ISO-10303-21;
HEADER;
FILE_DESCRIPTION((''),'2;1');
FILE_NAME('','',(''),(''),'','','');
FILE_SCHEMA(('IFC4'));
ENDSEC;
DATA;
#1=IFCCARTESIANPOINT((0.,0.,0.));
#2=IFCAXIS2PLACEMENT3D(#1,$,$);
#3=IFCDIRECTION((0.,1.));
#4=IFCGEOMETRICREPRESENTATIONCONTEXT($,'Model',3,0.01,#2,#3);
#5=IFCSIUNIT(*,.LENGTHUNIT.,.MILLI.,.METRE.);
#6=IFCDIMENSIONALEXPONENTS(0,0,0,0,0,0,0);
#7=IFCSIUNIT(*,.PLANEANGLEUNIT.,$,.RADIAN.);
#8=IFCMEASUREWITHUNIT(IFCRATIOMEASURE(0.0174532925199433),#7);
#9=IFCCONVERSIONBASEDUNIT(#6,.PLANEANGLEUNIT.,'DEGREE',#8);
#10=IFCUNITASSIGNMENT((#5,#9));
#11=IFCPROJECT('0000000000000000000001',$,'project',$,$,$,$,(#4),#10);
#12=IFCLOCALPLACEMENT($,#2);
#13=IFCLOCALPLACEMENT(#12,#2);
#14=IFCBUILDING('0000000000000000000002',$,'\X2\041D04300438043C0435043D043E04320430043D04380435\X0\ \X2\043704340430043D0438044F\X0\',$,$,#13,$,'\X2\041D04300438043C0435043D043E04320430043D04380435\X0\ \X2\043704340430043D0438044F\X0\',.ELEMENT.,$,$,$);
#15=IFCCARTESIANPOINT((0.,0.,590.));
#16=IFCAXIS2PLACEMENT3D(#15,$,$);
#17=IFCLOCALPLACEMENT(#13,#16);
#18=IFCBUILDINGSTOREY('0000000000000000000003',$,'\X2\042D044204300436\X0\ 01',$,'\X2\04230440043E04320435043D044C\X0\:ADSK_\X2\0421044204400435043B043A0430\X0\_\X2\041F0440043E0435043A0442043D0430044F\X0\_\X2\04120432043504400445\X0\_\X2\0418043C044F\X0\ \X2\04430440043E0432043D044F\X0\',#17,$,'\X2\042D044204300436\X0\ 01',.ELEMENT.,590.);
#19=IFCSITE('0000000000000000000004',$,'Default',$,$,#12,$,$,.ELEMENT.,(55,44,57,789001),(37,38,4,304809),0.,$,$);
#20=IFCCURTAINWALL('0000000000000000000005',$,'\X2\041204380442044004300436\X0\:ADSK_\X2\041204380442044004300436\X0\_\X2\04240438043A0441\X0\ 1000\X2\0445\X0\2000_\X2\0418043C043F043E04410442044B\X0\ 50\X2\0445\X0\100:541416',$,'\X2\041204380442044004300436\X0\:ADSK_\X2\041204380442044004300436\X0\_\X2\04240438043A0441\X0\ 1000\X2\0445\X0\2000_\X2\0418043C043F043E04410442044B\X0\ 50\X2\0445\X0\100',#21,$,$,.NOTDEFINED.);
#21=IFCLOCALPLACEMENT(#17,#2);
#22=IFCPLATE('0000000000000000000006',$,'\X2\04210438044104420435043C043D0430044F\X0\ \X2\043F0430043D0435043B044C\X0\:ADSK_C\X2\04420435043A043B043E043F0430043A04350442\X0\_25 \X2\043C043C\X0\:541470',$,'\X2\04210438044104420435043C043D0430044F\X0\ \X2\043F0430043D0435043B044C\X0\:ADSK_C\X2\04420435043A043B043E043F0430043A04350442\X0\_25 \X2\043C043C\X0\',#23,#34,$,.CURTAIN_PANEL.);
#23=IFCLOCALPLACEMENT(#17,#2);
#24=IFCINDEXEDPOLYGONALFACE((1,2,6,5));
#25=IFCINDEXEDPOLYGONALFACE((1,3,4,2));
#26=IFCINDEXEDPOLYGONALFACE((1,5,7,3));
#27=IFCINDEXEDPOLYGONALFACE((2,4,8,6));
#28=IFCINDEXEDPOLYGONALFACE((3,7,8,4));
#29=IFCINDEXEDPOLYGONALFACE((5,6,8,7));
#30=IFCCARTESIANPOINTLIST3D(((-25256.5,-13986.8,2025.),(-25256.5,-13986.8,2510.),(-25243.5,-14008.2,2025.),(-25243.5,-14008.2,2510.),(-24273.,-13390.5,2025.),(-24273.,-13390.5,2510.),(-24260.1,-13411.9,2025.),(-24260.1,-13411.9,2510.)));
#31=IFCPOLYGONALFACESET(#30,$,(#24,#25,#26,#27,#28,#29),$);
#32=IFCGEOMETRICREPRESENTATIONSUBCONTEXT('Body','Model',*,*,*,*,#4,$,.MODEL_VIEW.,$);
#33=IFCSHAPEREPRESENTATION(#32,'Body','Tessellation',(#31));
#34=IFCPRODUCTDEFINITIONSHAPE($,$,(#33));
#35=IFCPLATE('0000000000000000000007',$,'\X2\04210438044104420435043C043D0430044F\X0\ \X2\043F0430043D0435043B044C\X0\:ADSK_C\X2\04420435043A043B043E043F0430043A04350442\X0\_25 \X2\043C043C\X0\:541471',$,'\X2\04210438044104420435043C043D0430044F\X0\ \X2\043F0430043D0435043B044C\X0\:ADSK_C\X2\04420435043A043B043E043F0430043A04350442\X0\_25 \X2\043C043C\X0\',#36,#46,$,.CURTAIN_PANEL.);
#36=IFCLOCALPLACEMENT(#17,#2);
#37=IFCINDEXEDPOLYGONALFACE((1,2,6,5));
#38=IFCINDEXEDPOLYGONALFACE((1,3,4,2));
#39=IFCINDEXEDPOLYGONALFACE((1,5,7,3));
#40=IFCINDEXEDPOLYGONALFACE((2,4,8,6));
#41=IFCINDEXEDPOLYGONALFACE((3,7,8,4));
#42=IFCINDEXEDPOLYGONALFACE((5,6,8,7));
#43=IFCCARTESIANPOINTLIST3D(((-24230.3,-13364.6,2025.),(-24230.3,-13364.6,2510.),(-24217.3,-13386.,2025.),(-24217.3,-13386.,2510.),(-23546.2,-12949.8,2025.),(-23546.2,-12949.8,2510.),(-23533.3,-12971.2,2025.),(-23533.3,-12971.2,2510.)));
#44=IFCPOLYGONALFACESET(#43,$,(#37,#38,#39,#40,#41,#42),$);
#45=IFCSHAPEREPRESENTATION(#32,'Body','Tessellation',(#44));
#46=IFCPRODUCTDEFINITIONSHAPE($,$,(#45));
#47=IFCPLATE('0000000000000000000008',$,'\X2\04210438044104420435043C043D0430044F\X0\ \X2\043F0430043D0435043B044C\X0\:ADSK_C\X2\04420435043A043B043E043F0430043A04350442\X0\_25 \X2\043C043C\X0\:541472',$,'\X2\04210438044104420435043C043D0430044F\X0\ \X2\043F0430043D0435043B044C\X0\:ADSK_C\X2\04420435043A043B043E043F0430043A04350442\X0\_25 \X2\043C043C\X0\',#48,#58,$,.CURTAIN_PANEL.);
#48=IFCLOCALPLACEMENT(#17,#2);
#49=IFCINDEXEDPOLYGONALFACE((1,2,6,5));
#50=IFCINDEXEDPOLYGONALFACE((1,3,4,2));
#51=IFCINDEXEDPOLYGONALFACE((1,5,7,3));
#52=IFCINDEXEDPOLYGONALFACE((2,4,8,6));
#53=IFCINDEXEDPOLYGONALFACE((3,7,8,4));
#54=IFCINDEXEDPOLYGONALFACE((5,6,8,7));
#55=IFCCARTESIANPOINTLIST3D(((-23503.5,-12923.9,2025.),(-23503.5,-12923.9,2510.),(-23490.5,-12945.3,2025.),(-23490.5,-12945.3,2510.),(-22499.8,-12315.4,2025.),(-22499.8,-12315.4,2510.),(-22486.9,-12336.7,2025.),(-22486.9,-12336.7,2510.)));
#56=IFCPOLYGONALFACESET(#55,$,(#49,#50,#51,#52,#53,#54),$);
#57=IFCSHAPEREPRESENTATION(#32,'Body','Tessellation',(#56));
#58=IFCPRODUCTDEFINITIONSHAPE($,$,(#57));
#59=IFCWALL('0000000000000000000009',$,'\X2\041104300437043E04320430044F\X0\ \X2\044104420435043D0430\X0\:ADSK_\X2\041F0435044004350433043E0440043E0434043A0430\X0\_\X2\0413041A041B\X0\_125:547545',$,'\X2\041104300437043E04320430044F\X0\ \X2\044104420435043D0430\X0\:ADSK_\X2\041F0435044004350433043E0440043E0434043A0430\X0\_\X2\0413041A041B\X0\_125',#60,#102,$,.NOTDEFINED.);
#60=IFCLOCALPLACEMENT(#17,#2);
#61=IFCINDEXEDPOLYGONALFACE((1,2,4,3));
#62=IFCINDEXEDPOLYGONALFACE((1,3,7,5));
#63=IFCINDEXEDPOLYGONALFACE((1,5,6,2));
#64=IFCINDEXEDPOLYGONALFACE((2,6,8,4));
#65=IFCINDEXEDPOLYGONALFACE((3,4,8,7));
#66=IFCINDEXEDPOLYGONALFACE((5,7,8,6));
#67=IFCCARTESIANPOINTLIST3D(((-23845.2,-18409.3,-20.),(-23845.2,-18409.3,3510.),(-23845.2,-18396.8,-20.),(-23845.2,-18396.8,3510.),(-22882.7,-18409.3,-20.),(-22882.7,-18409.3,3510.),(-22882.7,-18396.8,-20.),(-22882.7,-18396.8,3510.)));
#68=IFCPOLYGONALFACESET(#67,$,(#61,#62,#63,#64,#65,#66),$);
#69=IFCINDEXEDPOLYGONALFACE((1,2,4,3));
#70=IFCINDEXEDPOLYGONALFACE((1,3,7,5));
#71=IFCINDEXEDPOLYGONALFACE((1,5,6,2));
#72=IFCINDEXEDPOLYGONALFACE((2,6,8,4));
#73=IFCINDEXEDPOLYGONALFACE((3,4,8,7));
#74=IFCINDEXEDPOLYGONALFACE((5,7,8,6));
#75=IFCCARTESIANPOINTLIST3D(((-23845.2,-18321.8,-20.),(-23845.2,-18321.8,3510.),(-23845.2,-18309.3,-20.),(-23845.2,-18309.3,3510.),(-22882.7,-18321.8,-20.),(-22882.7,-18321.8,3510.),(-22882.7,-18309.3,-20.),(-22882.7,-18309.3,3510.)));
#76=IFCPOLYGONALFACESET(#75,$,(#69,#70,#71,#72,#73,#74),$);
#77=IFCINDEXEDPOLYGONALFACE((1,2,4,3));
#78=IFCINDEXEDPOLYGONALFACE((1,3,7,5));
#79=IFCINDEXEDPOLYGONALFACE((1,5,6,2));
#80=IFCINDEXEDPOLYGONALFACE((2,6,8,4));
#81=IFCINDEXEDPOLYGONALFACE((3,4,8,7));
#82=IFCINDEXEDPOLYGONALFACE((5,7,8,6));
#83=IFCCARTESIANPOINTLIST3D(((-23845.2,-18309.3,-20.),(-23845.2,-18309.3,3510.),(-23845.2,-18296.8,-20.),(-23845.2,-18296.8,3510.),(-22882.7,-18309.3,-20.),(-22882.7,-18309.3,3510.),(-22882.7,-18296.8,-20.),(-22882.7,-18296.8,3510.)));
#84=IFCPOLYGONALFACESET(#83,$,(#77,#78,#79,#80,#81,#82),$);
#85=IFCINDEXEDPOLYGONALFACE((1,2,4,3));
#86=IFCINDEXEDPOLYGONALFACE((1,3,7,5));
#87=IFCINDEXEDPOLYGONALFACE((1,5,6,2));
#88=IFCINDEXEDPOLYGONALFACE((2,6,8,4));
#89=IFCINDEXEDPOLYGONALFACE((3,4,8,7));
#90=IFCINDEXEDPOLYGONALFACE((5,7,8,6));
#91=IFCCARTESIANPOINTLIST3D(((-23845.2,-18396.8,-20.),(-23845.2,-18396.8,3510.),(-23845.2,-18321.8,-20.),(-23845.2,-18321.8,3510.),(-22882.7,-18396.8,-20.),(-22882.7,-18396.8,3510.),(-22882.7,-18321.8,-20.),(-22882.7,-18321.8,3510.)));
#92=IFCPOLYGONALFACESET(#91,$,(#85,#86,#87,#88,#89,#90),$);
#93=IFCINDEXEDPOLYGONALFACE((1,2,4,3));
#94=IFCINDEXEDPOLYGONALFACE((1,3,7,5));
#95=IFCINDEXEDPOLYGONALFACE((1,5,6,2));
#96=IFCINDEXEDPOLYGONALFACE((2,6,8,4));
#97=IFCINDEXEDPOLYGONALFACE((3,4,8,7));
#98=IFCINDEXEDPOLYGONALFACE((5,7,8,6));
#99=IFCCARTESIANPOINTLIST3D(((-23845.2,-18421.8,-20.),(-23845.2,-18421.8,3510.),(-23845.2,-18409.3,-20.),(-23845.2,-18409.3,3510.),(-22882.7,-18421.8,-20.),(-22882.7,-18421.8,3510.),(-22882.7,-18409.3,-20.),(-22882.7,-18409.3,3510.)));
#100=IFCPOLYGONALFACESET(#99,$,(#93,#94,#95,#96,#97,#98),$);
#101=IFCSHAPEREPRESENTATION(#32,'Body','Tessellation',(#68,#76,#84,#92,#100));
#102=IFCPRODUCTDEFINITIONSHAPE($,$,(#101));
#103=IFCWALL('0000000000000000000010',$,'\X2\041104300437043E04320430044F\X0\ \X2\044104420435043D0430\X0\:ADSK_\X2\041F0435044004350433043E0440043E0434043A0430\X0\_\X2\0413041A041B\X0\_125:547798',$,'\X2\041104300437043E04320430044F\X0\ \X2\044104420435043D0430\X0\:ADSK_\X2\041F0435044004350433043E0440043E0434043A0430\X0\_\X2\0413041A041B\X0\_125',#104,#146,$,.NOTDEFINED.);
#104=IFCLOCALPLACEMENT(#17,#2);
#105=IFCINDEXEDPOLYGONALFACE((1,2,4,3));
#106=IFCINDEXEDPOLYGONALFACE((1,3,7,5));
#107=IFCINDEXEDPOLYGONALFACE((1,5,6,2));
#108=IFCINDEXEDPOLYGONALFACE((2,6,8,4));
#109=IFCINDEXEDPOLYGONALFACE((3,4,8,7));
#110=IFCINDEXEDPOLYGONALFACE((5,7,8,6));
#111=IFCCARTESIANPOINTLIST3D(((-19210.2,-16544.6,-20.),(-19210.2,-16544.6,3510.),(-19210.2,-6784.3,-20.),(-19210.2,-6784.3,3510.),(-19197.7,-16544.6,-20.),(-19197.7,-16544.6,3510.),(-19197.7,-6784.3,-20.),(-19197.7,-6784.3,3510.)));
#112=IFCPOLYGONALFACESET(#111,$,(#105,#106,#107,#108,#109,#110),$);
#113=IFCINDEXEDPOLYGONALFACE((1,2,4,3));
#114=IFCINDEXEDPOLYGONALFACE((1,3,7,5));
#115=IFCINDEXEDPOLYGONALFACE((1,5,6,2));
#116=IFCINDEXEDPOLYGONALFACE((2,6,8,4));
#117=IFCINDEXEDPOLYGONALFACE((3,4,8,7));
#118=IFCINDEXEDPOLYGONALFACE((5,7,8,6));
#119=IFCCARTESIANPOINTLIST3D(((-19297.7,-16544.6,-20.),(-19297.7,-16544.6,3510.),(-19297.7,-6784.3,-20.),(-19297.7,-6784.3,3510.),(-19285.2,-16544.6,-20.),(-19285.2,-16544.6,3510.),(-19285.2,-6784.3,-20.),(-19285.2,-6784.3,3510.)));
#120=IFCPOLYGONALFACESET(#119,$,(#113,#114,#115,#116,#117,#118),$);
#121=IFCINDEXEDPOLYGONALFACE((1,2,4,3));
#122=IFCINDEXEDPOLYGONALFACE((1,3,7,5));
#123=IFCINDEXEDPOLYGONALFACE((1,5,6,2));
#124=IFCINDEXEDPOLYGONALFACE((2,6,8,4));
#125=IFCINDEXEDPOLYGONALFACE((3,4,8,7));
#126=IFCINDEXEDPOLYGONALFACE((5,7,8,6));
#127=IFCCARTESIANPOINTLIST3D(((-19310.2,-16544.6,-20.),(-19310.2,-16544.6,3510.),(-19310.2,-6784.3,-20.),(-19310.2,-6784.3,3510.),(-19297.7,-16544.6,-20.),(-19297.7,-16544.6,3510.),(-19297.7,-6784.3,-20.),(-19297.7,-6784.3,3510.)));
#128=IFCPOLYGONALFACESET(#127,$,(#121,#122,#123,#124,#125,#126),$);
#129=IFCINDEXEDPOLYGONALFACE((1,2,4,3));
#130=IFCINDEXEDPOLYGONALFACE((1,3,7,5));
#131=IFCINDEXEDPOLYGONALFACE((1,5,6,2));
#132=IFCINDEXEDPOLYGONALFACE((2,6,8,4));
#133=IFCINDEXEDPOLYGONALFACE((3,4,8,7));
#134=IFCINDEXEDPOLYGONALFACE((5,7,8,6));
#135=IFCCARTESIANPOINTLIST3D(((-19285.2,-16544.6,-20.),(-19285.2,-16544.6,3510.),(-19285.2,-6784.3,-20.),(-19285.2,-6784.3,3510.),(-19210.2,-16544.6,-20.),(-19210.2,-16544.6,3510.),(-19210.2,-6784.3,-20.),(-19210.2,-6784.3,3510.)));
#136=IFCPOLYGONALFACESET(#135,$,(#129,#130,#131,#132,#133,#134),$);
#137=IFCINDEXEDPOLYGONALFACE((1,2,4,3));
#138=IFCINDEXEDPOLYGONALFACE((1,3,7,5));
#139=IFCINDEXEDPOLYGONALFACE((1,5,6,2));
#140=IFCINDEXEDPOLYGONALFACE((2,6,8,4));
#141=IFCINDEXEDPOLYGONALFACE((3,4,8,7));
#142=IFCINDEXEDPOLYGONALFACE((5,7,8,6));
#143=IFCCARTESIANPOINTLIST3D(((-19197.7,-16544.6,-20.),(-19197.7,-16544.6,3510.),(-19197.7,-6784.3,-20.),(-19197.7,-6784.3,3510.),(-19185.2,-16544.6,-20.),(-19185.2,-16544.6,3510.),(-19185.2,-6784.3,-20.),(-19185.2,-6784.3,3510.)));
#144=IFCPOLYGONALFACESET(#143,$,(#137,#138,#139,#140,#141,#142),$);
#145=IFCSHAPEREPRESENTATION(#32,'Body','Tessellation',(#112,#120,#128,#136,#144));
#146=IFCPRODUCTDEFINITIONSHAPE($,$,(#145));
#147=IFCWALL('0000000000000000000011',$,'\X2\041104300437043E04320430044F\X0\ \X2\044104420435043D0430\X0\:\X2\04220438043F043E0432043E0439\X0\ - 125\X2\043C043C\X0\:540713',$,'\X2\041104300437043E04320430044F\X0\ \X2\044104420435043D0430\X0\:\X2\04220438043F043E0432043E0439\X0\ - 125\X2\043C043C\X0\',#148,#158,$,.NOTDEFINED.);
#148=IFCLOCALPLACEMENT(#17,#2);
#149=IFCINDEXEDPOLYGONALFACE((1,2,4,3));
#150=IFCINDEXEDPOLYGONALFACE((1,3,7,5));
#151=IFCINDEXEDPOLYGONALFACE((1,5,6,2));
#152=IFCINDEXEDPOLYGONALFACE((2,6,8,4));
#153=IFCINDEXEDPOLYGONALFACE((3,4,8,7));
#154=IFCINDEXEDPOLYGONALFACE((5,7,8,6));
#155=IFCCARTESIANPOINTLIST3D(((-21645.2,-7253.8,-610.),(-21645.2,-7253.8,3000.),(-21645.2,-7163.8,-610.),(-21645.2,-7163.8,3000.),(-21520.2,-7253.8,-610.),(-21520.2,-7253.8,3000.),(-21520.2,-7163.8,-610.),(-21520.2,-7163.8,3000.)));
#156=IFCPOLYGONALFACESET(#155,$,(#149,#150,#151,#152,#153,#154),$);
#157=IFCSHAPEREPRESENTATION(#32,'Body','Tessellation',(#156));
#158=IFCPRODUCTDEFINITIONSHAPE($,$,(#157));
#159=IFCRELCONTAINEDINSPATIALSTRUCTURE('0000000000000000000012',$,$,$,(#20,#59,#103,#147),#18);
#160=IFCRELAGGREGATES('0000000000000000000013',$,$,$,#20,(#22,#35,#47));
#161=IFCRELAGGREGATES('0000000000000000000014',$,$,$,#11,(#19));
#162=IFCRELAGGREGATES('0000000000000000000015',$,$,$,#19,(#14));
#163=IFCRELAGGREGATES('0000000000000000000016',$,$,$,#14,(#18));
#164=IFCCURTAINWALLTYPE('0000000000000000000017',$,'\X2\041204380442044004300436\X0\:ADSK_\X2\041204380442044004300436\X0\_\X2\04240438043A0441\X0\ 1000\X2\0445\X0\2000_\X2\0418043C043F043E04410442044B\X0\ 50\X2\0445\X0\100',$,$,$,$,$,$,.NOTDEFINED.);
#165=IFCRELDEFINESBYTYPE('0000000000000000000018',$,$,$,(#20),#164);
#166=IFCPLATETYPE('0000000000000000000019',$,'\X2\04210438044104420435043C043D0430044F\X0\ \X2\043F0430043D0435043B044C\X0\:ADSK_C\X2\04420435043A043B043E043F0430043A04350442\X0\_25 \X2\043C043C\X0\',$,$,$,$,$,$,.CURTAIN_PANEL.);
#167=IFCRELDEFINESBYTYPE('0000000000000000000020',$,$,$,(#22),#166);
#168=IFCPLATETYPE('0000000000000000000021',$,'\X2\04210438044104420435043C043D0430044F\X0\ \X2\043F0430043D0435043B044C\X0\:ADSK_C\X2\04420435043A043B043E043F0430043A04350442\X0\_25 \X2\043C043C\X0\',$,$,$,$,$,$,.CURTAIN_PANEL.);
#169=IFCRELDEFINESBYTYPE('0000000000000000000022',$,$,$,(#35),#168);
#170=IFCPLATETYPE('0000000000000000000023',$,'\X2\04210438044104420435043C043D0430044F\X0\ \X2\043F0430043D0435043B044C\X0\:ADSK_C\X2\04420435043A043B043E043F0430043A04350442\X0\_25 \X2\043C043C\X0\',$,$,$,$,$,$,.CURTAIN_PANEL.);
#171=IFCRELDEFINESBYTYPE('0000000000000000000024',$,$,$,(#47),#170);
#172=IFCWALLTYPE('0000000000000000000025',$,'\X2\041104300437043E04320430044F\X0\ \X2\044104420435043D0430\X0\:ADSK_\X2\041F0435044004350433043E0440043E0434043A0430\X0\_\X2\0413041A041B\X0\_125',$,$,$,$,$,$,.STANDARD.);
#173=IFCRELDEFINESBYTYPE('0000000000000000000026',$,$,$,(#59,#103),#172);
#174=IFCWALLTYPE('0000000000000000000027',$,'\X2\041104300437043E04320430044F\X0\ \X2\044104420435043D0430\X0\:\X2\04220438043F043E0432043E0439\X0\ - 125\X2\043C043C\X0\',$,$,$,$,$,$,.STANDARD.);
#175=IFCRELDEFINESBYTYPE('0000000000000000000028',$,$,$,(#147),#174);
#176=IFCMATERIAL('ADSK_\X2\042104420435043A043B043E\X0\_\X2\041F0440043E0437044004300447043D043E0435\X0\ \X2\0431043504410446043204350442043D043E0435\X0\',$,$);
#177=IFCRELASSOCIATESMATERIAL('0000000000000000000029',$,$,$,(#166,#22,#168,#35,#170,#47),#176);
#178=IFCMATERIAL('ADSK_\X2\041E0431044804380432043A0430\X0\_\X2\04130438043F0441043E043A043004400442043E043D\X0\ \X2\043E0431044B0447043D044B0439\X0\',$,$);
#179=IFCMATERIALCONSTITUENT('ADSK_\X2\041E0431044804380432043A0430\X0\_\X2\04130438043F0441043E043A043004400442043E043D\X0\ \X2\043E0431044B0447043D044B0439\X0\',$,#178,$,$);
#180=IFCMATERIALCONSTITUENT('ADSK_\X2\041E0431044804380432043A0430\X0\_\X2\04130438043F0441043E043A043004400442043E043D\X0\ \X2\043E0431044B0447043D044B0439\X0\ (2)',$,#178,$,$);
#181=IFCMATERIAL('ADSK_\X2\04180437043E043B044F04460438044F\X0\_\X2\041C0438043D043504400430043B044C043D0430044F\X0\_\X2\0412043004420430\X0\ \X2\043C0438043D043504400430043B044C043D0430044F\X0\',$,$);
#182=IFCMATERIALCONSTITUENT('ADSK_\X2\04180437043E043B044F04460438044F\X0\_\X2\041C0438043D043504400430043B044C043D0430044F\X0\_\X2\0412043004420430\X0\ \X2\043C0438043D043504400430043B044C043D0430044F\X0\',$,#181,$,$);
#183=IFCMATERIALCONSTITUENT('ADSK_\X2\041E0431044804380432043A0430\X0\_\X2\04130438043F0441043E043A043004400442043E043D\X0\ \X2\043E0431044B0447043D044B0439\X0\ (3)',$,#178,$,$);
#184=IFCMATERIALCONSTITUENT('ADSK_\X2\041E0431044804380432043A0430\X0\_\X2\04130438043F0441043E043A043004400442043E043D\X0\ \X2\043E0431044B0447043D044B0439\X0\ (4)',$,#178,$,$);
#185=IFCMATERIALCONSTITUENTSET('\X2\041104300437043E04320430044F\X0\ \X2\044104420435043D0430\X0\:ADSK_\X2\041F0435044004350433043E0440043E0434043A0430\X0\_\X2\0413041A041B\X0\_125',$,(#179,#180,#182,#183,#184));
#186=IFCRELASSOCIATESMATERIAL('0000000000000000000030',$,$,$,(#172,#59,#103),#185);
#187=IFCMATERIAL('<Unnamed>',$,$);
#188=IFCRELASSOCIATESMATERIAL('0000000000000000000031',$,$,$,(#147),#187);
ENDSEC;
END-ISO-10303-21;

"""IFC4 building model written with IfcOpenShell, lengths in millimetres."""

from ifc_helpers import new_model, entity, si_unit, converted_unit, direction, frame, origin, place, context, subcontext, project, spatial, indexed_curve, outline, extrude, source, transform, mapped, material, constituent, constituent_set, type_object, type_shapes, element, aggregate, save


model = new_model("IFC4")

# Units and contexts
model_context = context("Model", 3, precision=0.01, world=origin(), true_north=direction((0.0, 1.0)))
body_context = subcontext(model_context, "Body", "Model", "MODEL_VIEW")
ifc_project = project(units=[si_unit("LENGTHUNIT", "METRE", prefix="MILLI"), converted_unit("PLANEANGLEUNIT", "DEGREE", entity("IfcRatioMeasure", 0.0174532925199433), si_unit("PLANEANGLEUNIT", "RADIAN"), dimensions=[0, 0, 0, 0, 0, 0, 0])], contexts=[model_context])

# Site, building, storey
site_placement = place(None, origin())
site = spatial("IfcSite", under=ifc_project, at=site_placement, Name="Default", CompositionType="ELEMENT", RefLatitude=(55, 44, 57, 789001), RefLongitude=(37, 38, 4, 304809), RefElevation=0.0)
building_placement = place(site_placement, origin())
building = spatial("IfcBuilding", under=site, at=building_placement, Name="Наименование здания", LongName="Наименование здания", CompositionType="ELEMENT")
storey_placement = place(building_placement, frame((0.0, 0.0, 590.0)))
storey = spatial("IfcBuildingStorey", under=building, at=storey_placement, Name="Этаж 01", ObjectType="Уровень:ADSK_Стрелка_Проектная_Вверх_Имя уровня", LongName="Этаж 01", CompositionType="ELEMENT", Elevation=590.0)

# Curtain wall
curtain_wall_type = type_object("IfcCurtainWallType", Name="Витраж:ADSK_Витраж_Фикс 1000х2000_Импосты 50х100", PredefinedType="NOTDEFINED")
curtain_wall_placement = place(storey_placement, frame((0.0, 0.0, -590.0)))
curtain_wall = element("IfcCurtainWall", 1, at=curtain_wall_placement, inside=storey, type_object=curtain_wall_type, Name="Витраж:ADSK_Витраж_Фикс 1000х2000_Импосты 50х100:541416", ObjectType="Витраж:ADSK_Витраж_Фикс 1000х2000_Импосты 50х100", PredefinedType="NOTDEFINED")
ifc_material_1 = material(Name="<Unnamed>")

# Plates
ifc_material_2 = material(Name="ADSK_Стекло_Прозрачное бесцветное")
plate_type_1 = type_object("IfcPlateType", Name="Системная панель:ADSK_Cтеклопакет_25 мм", PredefinedType="CURTAIN_PANEL", material=ifc_material_2)
shared_shape_1 = source(origin(), body_context, "Body", "SweptSolid", [
    extrude(outline(indexed_curve([(-12.5, -575.1), (12.5, -575.1), (12.5, 575.1), (-12.5, 575.1), (-12.5, -575.1)], self_intersect=False)), frame((0.0, 0.0, 0.0), z_axis=(0.0, 0.0, 1.0), x_axis=(0.0, 1.0, 0.0)), (0.0, 0.0, 1.0), 485.0),
])
type_shapes(plate_type_1, [shared_shape_1])
plate_1_placement = place(curtain_wall_placement, frame((-24758.3, -13699.3, 2615.0), z_axis=(0.0, 0.0, 1.0), x_axis=(0.855102, 0.51846, 0.0)))
plate_1 = element("IfcPlate", 2, at=plate_1_placement, type_object=plate_type_1, material=ifc_material_2, Name="Системная панель:ADSK_Cтеклопакет_25 мм:541470", ObjectType="Системная панель:ADSK_Cтеклопакет_25 мм", PredefinedType="CURTAIN_PANEL", context=body_context, shape_type="MappedRepresentation", body=[
    mapped(shared_shape_1, transform((0.0, 0.0, 0.0), scale=1.0)),
])
plate_type_2 = type_object("IfcPlateType", Name="Системная панель:ADSK_Cтеклопакет_25 мм", PredefinedType="CURTAIN_PANEL", material=ifc_material_2)
shared_shape_2 = source(origin(), body_context, "Body", "SweptSolid", [
    extrude(outline(indexed_curve([(-12.5, -400.0), (12.5, -400.0), (12.5, 400.0), (-12.5, 400.0), (-12.5, -400.0)], self_intersect=False)), frame((0.0, 0.0, 0.0), z_axis=(0.0, 0.0, 1.0), x_axis=(0.0, 1.0, 0.0)), (0.0, 0.0, 1.0), 485.0),
])
type_shapes(plate_type_2, [shared_shape_2])
plate_2_placement = place(curtain_wall_placement, frame((-23881.8, -13167.9, 2615.0), z_axis=(0.0, 0.0, 1.0), x_axis=(0.855102, 0.51846, 0.0)))
plate_2 = element("IfcPlate", 3, at=plate_2_placement, type_object=plate_type_2, material=ifc_material_2, Name="Системная панель:ADSK_Cтеклопакет_25 мм:541471", ObjectType="Системная панель:ADSK_Cтеклопакет_25 мм", PredefinedType="CURTAIN_PANEL", context=body_context, shape_type="MappedRepresentation", body=[
    mapped(shared_shape_2, transform((0.0, 0.0, 0.0), scale=1.0)),
])
plate_type_3 = type_object("IfcPlateType", Name="Системная панель:ADSK_Cтеклопакет_25 мм", PredefinedType="CURTAIN_PANEL", material=ifc_material_2)
shared_shape_3 = source(origin(), body_context, "Body", "SweptSolid", [
    extrude(outline(indexed_curve([(-12.5, -586.9), (12.5, -586.9), (12.5, 586.9), (-12.5, 586.9), (-12.5, -586.9)], self_intersect=False)), frame((0.0, 0.0, 0.0), z_axis=(0.0, 0.0, 1.0), x_axis=(0.0, 1.0, 0.0)), (0.0, 0.0, 1.0), 485.0),
])
type_shapes(plate_type_3, [shared_shape_3])
plate_3_placement = place(curtain_wall_placement, frame((-22995.2, -12630.3, 2615.0), z_axis=(0.0, 0.0, 1.0), x_axis=(0.855102, 0.51846, 0.0)))
plate_3 = element("IfcPlate", 4, at=plate_3_placement, type_object=plate_type_3, material=ifc_material_2, Name="Системная панель:ADSK_Cтеклопакет_25 мм:541472", ObjectType="Системная панель:ADSK_Cтеклопакет_25 мм", PredefinedType="CURTAIN_PANEL", context=body_context, shape_type="MappedRepresentation", body=[
    mapped(shared_shape_3, transform((0.0, 0.0, 0.0), scale=1.0)),
])
aggregate(curtain_wall, [plate_1, plate_2, plate_3])

# Shared definitions
ifc_material_3 = material(Name="ADSK_Обшивка_Гипсокартон обычный")
ifc_constituent_1 = constituent(ifc_material_3, Name="ADSK_Обшивка_Гипсокартон обычный")
ifc_constituent_2 = constituent(ifc_material_3, Name="ADSK_Обшивка_Гипсокартон обычный (2)")
ifc_material_4 = material(Name="ADSK_Изоляция_Минеральная_Вата минеральная")
ifc_constituent_3 = constituent(ifc_material_4, Name="ADSK_Изоляция_Минеральная_Вата минеральная")
ifc_constituent_4 = constituent(ifc_material_3, Name="ADSK_Обшивка_Гипсокартон обычный (3)")
ifc_constituent_5 = constituent(ifc_material_3, Name="ADSK_Обшивка_Гипсокартон обычный (4)")
ifc_constituent_set_1 = constituent_set(constituents=[ifc_constituent_1, ifc_constituent_2, ifc_constituent_3, ifc_constituent_4, ifc_constituent_5], Name="Базовая стена:ADSK_Перегородка_ГКЛ_125")
wall_type_1 = type_object("IfcWallType", Name="Базовая стена:ADSK_Перегородка_ГКЛ_125", PredefinedType="STANDARD", material=ifc_constituent_set_1)

# Walls
wall_1_placement = place(storey_placement, frame((-23845.2, -18359.3, -20.0)))
element("IfcWall", 5, at=wall_1_placement, inside=storey, type_object=wall_type_1, material=ifc_constituent_set_1, Name="Базовая стена:ADSK_Перегородка_ГКЛ_125:547545", ObjectType="Базовая стена:ADSK_Перегородка_ГКЛ_125", PredefinedType="NOTDEFINED", context=body_context, shape_type="SweptSolid", body=[
    extrude(outline(indexed_curve([(-481.3, -6.2), (481.3, -6.2), (481.3, 6.3), (-481.3, 6.3), (-481.3, -6.2)], self_intersect=False)), frame((481.3, -43.8, 0.0)), (0.0, 0.0, 1.0), 3530.0),
    extrude(outline(indexed_curve([(-481.3, -6.3), (481.3, -6.3), (481.3, 6.2), (-481.3, 6.2), (-481.3, -6.3)], self_intersect=False)), frame((481.3, 43.8, 0.0)), (0.0, 0.0, 1.0), 3530.0),
    extrude(outline(indexed_curve([(-6.3, -481.3), (6.3, -481.3), (6.3, 481.3), (-6.3, 481.3), (-6.3, -481.3)], self_intersect=False)), frame((481.3, 56.3, 0.0), z_axis=(0.0, 0.0, 1.0), x_axis=(0.0, -1.0, 0.0)), (0.0, 0.0, 1.0), 3530.0),
    extrude(outline(indexed_curve([(-481.3, -37.5), (481.3, -37.5), (481.3, 37.5), (-481.3, 37.5), (-481.3, -37.5)], self_intersect=False)), frame((481.3, 0.0, 0.0)), (0.0, 0.0, 1.0), 3530.0),
    extrude(outline(indexed_curve([(-6.3, -481.3), (6.2, -481.3), (6.2, 481.3), (-6.3, 481.3), (-6.3, -481.3)], self_intersect=False)), frame((481.3, -56.2, 0.0), z_axis=(0.0, 0.0, 1.0), x_axis=(0.0, 1.0, 0.0)), (0.0, 0.0, 1.0), 3530.0),
])
wall_2_placement = place(storey_placement, frame((-19247.7, -16544.6, -20.0), z_axis=(0.0, 0.0, 1.0), x_axis=(0.0, 1.0, 0.0)))
element("IfcWall", 6, at=wall_2_placement, inside=storey, type_object=wall_type_1, material=ifc_constituent_set_1, Name="Базовая стена:ADSK_Перегородка_ГКЛ_125:547798", ObjectType="Базовая стена:ADSK_Перегородка_ГКЛ_125", PredefinedType="NOTDEFINED", context=body_context, shape_type="SweptSolid", body=[
    extrude(outline(indexed_curve([(-4880.1, -6.2), (4880.1, -6.2), (4880.1, 6.3), (-4880.1, 6.3), (-4880.1, -6.2)], self_intersect=False)), frame((4880.1, -43.8, 0.0)), (0.0, 0.0, 1.0), 3530.0),
    extrude(outline(indexed_curve([(-4880.1, -6.3), (4880.1, -6.3), (4880.1, 6.2), (-4880.1, 6.2), (-4880.1, -6.3)], self_intersect=False)), frame((4880.1, 43.8, 0.0)), (0.0, 0.0, 1.0), 3530.0),
    extrude(outline(indexed_curve([(-6.3, -4880.1), (6.3, -4880.1), (6.3, 4880.1), (-6.3, 4880.1), (-6.3, -4880.1)], self_intersect=False)), frame((4880.1, 56.3, 0.0), z_axis=(0.0, 0.0, 1.0), x_axis=(0.0, -1.0, 0.0)), (0.0, 0.0, 1.0), 3530.0),
    extrude(outline(indexed_curve([(-4880.1, -37.5), (4880.1, -37.5), (4880.1, 37.5), (-4880.1, 37.5), (-4880.1, -37.5)], self_intersect=False)), frame((4880.1, 0.0, 0.0)), (0.0, 0.0, 1.0), 3530.0),
    extrude(outline(indexed_curve([(-6.3, -4880.1), (6.2, -4880.1), (6.2, 4880.1), (-6.3, 4880.1), (-6.3, -4880.1)], self_intersect=False)), frame((4880.1, -56.2, 0.0), z_axis=(0.0, 0.0, 1.0), x_axis=(0.0, 1.0, 0.0)), (0.0, 0.0, 1.0), 3530.0),
])
wall_type_2 = type_object("IfcWallType", Name="Базовая стена:Типовой - 125мм", PredefinedType="STANDARD")
wall_3_placement = place(storey_placement, frame((-21582.7, -7253.8, -610.0), z_axis=(0.0, 0.0, 1.0), x_axis=(0.0, 1.0, 0.0)))
element("IfcWall", 7, at=wall_3_placement, inside=storey, type_object=wall_type_2, material=ifc_material_1, Name="Базовая стена:Типовой - 125мм:540713", ObjectType="Базовая стена:Типовой - 125мм", PredefinedType="NOTDEFINED", context=body_context, shape_type="SweptSolid", body=[
    extrude(outline(indexed_curve([(90.0, 62.5), (0.0, 62.5), (0.0, -62.5), (90.0, -62.5), (90.0, 62.5)], self_intersect=False)), origin(), (0.0, 0.0, 1.0), 3610.0),
])

save(model, "model.ifc")
